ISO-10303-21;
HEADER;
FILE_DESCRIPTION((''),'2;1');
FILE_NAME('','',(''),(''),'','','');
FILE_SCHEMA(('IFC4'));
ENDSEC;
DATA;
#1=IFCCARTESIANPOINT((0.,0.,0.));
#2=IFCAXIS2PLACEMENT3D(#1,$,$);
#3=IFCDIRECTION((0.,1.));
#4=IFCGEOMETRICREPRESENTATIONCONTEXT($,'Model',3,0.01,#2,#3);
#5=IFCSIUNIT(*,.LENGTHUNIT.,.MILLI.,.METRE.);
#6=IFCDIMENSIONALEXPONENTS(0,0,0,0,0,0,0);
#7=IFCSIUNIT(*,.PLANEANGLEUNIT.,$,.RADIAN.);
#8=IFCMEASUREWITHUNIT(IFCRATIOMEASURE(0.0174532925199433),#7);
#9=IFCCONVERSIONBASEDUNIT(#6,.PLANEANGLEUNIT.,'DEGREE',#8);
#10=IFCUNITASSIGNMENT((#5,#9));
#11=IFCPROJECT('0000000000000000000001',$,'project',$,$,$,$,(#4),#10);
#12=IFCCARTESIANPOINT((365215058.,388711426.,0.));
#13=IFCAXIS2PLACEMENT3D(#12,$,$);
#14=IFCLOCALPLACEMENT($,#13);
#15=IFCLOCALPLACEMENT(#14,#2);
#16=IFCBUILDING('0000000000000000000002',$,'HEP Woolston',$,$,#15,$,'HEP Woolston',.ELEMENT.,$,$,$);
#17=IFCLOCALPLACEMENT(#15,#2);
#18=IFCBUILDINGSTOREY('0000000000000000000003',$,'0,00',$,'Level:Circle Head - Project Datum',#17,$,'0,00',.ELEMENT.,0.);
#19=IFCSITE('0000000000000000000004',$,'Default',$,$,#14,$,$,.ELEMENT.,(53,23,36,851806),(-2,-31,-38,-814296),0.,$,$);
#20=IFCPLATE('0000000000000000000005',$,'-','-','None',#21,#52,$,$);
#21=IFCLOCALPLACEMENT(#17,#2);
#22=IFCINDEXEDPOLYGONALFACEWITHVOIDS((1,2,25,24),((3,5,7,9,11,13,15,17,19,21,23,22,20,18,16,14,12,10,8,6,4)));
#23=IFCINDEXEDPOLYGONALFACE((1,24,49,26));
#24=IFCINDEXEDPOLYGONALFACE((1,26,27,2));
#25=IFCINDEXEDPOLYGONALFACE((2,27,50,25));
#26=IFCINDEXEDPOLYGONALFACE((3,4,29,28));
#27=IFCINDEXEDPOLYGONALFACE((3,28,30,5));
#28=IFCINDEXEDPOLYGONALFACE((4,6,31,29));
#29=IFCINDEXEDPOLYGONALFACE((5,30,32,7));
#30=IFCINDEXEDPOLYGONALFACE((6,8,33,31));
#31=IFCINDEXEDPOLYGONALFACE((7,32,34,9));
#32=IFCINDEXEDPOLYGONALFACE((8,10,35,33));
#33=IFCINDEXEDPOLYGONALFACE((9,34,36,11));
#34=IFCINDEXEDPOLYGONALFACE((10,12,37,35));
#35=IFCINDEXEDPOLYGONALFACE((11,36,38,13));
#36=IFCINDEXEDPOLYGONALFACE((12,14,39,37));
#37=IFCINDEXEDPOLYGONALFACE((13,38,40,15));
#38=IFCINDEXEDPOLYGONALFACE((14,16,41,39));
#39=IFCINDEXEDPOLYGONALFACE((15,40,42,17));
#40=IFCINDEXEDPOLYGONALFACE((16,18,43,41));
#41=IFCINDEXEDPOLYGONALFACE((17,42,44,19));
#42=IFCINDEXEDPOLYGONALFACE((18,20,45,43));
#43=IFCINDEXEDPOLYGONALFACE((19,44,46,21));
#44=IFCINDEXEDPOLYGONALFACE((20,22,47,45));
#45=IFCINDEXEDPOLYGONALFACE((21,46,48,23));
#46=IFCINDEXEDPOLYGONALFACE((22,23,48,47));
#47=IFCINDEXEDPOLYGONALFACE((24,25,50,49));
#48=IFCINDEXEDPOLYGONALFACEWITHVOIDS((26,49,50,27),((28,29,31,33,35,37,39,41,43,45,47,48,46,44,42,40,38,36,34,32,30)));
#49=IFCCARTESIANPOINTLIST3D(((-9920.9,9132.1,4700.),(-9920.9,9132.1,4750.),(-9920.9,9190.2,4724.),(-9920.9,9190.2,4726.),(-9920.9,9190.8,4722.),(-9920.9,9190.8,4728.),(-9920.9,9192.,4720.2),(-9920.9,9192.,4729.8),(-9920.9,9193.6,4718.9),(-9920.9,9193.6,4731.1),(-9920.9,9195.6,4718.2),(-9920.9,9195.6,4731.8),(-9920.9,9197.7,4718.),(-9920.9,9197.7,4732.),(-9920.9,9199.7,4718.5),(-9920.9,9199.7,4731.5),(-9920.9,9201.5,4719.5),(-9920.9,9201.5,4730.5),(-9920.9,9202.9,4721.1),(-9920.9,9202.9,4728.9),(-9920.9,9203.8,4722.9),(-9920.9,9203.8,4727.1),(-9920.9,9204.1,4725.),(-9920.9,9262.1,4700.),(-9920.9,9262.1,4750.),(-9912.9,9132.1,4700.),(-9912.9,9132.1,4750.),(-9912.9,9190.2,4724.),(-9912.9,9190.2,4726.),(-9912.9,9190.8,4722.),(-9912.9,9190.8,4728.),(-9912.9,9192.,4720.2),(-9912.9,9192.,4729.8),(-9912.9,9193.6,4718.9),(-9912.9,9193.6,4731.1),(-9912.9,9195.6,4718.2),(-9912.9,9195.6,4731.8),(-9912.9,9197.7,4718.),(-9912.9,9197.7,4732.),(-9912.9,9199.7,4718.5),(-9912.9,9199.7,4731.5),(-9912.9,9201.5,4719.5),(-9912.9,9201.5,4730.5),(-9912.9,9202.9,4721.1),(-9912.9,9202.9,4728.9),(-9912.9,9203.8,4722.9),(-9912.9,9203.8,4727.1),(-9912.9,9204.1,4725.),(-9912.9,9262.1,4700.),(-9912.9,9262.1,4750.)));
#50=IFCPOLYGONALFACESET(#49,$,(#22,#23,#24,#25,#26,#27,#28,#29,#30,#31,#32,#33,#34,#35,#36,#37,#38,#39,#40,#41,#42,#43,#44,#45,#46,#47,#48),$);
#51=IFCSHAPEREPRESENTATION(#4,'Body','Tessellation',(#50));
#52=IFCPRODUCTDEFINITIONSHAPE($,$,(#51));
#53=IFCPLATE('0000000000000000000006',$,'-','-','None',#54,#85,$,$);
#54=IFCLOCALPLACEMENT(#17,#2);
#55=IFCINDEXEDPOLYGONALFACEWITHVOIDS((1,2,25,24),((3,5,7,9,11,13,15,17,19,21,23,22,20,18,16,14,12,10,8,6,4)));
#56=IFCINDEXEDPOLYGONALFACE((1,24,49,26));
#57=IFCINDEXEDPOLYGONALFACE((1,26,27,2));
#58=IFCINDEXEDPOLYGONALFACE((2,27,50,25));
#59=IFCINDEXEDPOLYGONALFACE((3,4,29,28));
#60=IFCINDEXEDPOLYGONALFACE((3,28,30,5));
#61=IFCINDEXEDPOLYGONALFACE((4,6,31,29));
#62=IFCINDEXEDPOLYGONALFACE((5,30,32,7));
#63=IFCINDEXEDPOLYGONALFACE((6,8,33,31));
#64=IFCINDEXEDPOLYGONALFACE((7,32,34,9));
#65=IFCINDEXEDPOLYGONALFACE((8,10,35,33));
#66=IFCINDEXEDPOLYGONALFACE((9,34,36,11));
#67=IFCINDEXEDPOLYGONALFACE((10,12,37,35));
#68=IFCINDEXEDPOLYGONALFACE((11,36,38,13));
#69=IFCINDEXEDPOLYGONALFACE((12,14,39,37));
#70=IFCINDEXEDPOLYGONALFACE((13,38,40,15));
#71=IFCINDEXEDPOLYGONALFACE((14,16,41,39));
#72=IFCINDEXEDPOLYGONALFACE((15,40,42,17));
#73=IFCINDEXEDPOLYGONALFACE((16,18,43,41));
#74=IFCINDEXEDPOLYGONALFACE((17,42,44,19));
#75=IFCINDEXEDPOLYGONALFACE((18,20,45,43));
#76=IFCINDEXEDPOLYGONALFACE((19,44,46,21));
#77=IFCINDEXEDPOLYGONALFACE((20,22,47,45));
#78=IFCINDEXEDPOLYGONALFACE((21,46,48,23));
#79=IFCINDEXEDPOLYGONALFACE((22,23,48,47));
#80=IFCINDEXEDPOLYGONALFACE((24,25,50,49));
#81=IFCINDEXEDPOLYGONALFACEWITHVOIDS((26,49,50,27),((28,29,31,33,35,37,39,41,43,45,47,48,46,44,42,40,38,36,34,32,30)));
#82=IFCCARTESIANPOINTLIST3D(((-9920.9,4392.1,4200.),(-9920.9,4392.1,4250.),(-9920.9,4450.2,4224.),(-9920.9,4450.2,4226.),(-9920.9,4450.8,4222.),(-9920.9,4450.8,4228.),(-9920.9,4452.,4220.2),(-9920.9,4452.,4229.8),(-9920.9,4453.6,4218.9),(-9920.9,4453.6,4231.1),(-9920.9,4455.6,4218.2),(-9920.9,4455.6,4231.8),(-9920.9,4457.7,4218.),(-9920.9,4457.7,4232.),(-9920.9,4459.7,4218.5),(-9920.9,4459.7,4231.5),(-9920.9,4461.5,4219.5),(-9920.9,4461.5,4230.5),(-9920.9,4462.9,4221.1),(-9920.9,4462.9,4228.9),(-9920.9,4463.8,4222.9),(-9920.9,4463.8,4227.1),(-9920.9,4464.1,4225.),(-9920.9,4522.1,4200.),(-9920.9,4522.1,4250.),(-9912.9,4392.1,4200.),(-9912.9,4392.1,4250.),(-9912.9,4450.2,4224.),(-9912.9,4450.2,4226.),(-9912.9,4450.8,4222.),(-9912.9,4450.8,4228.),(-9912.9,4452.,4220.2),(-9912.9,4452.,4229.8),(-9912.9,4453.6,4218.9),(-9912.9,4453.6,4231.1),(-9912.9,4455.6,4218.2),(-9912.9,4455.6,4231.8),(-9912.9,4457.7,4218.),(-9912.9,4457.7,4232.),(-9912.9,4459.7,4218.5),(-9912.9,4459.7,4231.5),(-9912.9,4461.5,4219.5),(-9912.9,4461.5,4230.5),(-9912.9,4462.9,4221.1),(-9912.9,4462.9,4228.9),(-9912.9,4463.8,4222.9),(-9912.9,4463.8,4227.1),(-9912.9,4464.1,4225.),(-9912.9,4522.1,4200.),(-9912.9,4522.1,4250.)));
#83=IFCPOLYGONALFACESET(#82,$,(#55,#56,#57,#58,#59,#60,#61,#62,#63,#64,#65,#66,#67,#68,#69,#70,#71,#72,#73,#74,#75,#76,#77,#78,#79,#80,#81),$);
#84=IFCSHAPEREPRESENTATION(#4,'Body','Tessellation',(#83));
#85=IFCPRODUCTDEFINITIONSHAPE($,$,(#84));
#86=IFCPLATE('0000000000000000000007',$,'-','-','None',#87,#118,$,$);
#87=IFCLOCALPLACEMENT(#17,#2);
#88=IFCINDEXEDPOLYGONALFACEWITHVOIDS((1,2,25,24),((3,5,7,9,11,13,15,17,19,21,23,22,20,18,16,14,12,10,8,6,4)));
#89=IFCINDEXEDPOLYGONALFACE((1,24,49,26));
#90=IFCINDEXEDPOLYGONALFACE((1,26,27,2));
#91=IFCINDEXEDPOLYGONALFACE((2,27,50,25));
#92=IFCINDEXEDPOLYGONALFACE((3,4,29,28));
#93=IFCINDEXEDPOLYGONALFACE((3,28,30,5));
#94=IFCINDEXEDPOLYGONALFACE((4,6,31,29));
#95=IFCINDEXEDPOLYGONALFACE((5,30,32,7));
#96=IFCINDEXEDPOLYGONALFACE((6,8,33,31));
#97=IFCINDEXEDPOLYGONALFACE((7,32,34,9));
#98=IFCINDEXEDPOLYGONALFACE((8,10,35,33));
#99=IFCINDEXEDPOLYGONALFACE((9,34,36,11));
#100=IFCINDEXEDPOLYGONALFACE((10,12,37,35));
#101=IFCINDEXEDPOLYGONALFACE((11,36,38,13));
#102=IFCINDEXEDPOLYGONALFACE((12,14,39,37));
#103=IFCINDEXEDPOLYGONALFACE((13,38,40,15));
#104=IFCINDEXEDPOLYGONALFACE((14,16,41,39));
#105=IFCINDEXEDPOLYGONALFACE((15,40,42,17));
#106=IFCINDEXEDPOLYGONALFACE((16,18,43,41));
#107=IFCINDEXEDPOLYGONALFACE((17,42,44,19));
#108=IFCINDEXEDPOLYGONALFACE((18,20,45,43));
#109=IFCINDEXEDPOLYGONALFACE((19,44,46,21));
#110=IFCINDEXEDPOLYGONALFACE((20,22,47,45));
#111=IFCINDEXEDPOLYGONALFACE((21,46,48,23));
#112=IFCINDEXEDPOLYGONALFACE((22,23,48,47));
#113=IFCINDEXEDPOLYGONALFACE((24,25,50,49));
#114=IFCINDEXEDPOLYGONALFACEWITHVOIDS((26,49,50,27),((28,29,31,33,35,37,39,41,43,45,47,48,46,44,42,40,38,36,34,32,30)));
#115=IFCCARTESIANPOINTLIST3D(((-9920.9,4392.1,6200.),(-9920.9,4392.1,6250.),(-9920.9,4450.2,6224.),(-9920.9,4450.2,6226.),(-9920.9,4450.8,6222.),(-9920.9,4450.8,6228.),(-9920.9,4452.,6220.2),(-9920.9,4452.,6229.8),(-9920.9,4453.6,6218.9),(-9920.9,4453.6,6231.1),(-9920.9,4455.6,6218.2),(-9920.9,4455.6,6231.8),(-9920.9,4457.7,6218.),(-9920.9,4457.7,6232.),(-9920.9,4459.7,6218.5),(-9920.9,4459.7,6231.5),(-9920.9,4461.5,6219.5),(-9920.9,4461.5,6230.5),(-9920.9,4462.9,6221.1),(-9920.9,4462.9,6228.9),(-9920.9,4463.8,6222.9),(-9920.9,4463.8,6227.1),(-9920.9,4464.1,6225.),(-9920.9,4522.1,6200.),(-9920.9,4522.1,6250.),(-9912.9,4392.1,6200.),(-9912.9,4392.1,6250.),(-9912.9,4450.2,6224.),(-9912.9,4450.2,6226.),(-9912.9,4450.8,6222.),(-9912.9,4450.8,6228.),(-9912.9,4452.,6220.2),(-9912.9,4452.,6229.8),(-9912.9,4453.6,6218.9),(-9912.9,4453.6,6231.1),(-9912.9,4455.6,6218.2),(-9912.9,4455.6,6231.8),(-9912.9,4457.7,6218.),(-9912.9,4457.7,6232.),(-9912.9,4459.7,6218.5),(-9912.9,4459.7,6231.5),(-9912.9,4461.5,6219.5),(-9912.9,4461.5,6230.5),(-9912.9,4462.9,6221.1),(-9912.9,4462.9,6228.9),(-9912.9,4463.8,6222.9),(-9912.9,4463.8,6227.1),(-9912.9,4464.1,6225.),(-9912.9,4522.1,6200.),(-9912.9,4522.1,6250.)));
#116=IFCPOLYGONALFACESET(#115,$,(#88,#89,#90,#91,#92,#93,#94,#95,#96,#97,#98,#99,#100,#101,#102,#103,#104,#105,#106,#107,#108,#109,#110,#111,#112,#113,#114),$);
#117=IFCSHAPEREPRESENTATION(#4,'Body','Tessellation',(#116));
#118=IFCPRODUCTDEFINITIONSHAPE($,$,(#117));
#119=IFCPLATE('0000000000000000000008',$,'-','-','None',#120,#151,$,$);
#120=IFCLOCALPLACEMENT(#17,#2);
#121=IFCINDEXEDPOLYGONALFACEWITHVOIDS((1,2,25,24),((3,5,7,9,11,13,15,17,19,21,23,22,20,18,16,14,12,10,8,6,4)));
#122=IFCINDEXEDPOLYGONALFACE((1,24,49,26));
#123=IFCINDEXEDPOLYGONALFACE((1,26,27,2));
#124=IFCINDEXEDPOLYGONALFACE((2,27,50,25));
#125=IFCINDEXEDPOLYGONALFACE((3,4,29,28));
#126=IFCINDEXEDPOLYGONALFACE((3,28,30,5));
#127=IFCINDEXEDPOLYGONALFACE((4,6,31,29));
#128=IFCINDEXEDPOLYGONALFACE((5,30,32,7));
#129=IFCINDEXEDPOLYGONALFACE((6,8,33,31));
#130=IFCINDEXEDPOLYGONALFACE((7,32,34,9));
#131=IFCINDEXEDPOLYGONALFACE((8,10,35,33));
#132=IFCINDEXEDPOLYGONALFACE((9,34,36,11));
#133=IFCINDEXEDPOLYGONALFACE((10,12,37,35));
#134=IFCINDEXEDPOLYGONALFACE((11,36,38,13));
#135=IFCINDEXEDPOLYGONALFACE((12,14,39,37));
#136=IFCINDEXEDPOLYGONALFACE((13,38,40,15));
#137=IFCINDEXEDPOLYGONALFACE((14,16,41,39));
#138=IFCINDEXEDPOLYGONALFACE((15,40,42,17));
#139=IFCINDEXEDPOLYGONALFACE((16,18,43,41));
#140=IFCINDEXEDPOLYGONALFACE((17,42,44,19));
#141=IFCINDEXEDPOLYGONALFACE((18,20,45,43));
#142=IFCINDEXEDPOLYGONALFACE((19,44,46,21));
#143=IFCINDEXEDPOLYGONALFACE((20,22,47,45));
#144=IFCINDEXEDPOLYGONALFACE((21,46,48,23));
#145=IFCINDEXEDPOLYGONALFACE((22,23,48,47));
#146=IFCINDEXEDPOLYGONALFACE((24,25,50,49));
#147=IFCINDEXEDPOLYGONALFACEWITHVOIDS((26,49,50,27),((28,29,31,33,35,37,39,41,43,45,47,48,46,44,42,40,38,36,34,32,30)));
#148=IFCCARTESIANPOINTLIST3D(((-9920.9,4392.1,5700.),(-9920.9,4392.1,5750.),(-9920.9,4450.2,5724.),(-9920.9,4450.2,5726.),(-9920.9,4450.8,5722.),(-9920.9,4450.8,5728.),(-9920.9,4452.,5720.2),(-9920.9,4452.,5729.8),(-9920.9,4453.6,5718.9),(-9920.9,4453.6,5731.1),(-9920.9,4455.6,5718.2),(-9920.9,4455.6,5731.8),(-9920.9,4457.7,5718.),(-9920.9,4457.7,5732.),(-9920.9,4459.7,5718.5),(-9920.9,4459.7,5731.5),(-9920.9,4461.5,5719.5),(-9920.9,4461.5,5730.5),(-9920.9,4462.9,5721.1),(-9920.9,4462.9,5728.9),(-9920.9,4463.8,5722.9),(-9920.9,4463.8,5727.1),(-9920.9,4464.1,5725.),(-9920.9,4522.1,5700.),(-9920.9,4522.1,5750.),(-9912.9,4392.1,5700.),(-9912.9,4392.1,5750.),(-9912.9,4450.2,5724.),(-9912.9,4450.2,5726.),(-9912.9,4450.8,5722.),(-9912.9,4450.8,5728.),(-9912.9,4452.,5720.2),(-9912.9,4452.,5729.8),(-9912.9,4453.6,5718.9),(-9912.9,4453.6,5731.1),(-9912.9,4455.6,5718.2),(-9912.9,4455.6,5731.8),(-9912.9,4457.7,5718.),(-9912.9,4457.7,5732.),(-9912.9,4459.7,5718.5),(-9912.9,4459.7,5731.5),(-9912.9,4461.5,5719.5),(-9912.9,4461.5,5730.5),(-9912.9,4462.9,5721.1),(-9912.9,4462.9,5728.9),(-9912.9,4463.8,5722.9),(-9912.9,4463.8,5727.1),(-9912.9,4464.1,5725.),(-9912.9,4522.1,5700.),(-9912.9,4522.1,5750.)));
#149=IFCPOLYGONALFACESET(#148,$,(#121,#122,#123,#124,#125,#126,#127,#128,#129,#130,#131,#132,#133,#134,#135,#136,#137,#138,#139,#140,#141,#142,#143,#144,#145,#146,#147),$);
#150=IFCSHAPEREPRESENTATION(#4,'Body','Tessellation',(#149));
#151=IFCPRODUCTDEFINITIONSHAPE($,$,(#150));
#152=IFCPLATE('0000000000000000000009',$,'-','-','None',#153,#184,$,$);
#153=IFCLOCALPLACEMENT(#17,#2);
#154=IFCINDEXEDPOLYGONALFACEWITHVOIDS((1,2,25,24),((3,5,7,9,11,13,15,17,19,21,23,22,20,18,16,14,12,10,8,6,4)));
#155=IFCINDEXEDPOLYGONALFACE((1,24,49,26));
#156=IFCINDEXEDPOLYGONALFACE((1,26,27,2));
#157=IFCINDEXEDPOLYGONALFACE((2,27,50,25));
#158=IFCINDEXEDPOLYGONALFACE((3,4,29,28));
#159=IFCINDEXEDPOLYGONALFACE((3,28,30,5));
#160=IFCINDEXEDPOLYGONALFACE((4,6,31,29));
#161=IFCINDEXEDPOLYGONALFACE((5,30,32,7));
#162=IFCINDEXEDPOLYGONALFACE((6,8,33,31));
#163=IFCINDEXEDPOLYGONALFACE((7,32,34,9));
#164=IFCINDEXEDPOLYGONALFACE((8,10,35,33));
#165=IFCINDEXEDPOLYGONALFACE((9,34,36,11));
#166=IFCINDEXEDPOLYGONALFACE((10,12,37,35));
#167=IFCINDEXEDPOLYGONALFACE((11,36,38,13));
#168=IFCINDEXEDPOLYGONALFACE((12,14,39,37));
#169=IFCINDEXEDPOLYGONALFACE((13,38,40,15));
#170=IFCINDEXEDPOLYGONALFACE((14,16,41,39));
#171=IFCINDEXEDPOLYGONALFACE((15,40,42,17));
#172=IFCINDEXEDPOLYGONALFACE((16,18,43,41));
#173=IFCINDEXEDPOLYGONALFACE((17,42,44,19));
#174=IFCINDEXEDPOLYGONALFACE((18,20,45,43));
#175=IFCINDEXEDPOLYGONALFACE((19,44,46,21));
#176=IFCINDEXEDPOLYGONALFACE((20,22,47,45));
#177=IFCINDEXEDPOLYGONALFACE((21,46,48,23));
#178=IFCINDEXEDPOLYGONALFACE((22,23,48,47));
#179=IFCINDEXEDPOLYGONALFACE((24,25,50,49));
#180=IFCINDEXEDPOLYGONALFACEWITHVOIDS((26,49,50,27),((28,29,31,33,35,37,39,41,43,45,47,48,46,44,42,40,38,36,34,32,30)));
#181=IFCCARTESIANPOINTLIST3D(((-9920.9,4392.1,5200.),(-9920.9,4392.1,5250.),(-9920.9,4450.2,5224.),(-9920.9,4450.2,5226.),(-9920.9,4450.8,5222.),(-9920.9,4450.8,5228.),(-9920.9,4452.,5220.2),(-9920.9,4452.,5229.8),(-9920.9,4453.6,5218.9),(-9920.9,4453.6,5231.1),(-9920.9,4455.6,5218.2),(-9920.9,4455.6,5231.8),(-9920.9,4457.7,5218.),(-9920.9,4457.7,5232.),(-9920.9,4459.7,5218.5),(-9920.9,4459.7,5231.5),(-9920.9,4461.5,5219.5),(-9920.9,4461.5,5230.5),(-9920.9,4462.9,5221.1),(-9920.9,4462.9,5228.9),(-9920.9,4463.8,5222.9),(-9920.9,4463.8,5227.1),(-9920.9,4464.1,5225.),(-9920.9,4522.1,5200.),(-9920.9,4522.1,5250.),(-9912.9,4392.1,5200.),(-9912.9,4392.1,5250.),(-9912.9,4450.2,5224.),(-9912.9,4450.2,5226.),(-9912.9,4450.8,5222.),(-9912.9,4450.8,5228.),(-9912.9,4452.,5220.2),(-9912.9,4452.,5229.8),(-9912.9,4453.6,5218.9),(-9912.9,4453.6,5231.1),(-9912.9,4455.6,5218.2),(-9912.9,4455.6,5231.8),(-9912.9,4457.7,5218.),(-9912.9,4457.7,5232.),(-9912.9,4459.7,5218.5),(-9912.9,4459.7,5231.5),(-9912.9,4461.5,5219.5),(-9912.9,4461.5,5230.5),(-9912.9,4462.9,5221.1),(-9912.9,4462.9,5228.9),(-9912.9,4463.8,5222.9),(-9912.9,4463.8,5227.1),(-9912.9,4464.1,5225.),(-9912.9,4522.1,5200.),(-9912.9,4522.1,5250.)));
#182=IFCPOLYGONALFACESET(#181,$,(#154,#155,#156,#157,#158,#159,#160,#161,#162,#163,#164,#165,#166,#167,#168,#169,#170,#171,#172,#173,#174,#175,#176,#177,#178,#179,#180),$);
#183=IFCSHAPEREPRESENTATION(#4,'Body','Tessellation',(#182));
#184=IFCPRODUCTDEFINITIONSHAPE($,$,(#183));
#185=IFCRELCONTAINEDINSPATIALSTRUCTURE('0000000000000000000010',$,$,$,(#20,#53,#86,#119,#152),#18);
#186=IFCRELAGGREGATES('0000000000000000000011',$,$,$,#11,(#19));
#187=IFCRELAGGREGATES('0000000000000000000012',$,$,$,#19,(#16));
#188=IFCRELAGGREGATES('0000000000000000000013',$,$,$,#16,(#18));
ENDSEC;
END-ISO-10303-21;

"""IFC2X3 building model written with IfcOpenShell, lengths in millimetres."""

from ifc_helpers import new_model, entity, si_unit, converted_unit, direction, frame, origin, origin_with_axes, origin_2d_with_axis, place, context, project, spatial, polyline, circle, outline, extrude, element, save


model = new_model("IFC2X3")

# Units and contexts
model_context = context("Model", 3, precision=0.01, world=origin(), true_north=direction((0.0, 1.0)))
ifc_project = project(units=[si_unit("LENGTHUNIT", "METRE", prefix="MILLI"), converted_unit("PLANEANGLEUNIT", "DEGREE", entity("IfcRatioMeasure", 0.0174532925199433), si_unit("PLANEANGLEUNIT", "RADIAN"), dimensions=[0, 0, 0, 0, 0, 0, 0])], contexts=[model_context])

# Site, building, storey
site_placement = place(None, frame((365215058.0, 388711426.0, 0.0)))
site = spatial("IfcSite", under=ifc_project, at=site_placement, Name="Default", CompositionType="ELEMENT", RefLatitude=(53, 23, 36, 851806), RefLongitude=(-2, -31, -38, -814296), RefElevation=0.0)
building_placement = place(site_placement, origin())
building = spatial("IfcBuilding", under=site, at=building_placement, Name="HEP Woolston", LongName="HEP Woolston", CompositionType="ELEMENT")
storey_placement = place(building_placement, origin())
storey = spatial("IfcBuildingStorey", under=building, at=storey_placement, Name="0,00", ObjectType="Level:Circle Head - Project Datum", LongName="0,00", CompositionType="ELEMENT", Elevation=0.0)

# Plates, openings
plate_1_placement = place(storey_placement, frame((-9920.9, 9132.1, 4750.0), z_axis=(1.0, 0.0, 0.0), x_axis=(0.0, 1.0, 0.0)))
plate_1 = element("IfcPlate", 1, at=plate_1_placement, inside=storey, Name="-", Description="-", ObjectType="None", context=model_context, shape_type="SweptSolid", body=[
    extrude(outline(polyline([(0.0, -50.0), (130.0, -50.0), (130.0, 0.0), (0.0, 0.0), (0.0, -50.0)])), origin_with_axes(), (0.0, 0.0, 1.0), 8.0),
])
opening_1_placement = place(plate_1_placement, frame((65.0, -25.0, 8.5), z_axis=(0.0, 0.0, -1.0), x_axis=(1.0, 0.0, 0.0)))
element("IfcOpeningElement", 2, at=opening_1_placement, cuts=plate_1, ObjectType="Opening", context=model_context, shape_type="SweptSolid", body=[
    extrude(circle(Radius=7.0, at=origin_2d_with_axis()), origin(), (0.0, 0.0, 1.0), 9.0),
])
plate_2_placement = place(storey_placement, frame((-9920.9, 4392.1, 4250.0), z_axis=(1.0, 0.0, 0.0), x_axis=(0.0, 1.0, 0.0)))
plate_2 = element("IfcPlate", 3, at=plate_2_placement, inside=storey, Name="-", Description="-", ObjectType="None", context=model_context, shape_type="SweptSolid", body=[
    extrude(outline(polyline([(0.0, -50.0), (130.0, -50.0), (130.0, 0.0), (0.0, 0.0), (0.0, -50.0)])), origin_with_axes(), (0.0, 0.0, 1.0), 8.0),
])
opening_2_placement = place(plate_2_placement, frame((65.0, -25.0, 8.5), z_axis=(0.0, 0.0, -1.0), x_axis=(1.0, 0.0, 0.0)))
element("IfcOpeningElement", 4, at=opening_2_placement, cuts=plate_2, ObjectType="Opening", context=model_context, shape_type="SweptSolid", body=[
    extrude(circle(Radius=7.0, at=origin_2d_with_axis()), origin(), (0.0, 0.0, 1.0), 9.0),
])
plate_3_placement = place(storey_placement, frame((-9920.9, 4392.1, 6250.0), z_axis=(1.0, 0.0, 0.0), x_axis=(0.0, 1.0, 0.0)))
plate_3 = element("IfcPlate", 5, at=plate_3_placement, inside=storey, Name="-", Description="-", ObjectType="None", context=model_context, shape_type="SweptSolid", body=[
    extrude(outline(polyline([(0.0, -50.0), (130.0, -50.0), (130.0, 0.0), (0.0, 0.0), (0.0, -50.0)])), origin_with_axes(), (0.0, 0.0, 1.0), 8.0),
])
opening_3_placement = place(plate_3_placement, frame((65.0, -25.0, 8.5), z_axis=(0.0, 0.0, -1.0), x_axis=(1.0, 0.0, 0.0)))
element("IfcOpeningElement", 6, at=opening_3_placement, cuts=plate_3, ObjectType="Opening", context=model_context, shape_type="SweptSolid", body=[
    extrude(circle(Radius=7.0, at=origin_2d_with_axis()), origin(), (0.0, 0.0, 1.0), 9.0),
])
plate_4_placement = place(storey_placement, frame((-9920.9, 4392.1, 5750.0), z_axis=(1.0, 0.0, 0.0), x_axis=(0.0, 1.0, 0.0)))
plate_4 = element("IfcPlate", 7, at=plate_4_placement, inside=storey, Name="-", Description="-", ObjectType="None", context=model_context, shape_type="SweptSolid", body=[
    extrude(outline(polyline([(0.0, -50.0), (130.0, -50.0), (130.0, 0.0), (0.0, 0.0), (0.0, -50.0)])), origin_with_axes(), (0.0, 0.0, 1.0), 8.0),
])
opening_4_placement = place(plate_4_placement, frame((65.0, -25.0, 8.5), z_axis=(0.0, 0.0, -1.0), x_axis=(1.0, 0.0, 0.0)))
element("IfcOpeningElement", 8, at=opening_4_placement, cuts=plate_4, ObjectType="Opening", context=model_context, shape_type="SweptSolid", body=[
    extrude(circle(Radius=7.0, at=origin_2d_with_axis()), origin(), (0.0, 0.0, 1.0), 9.0),
])
plate_5_placement = place(storey_placement, frame((-9920.9, 4392.1, 5250.0), z_axis=(1.0, 0.0, 0.0), x_axis=(0.0, 1.0, 0.0)))
plate_5 = element("IfcPlate", 9, at=plate_5_placement, inside=storey, Name="-", Description="-", ObjectType="None", context=model_context, shape_type="SweptSolid", body=[
    extrude(outline(polyline([(0.0, -50.0), (130.0, -50.0), (130.0, 0.0), (0.0, 0.0), (0.0, -50.0)])), origin_with_axes(), (0.0, 0.0, 1.0), 8.0),
])
opening_5_placement = place(plate_5_placement, frame((65.0, -25.0, 8.5), z_axis=(0.0, 0.0, -1.0), x_axis=(1.0, 0.0, 0.0)))
element("IfcOpeningElement", 10, at=opening_5_placement, cuts=plate_5, ObjectType="Opening", context=model_context, shape_type="SweptSolid", body=[
    extrude(circle(Radius=7.0, at=origin_2d_with_axis()), origin(), (0.0, 0.0, 1.0), 9.0),
])

save(model, "model.ifc")
